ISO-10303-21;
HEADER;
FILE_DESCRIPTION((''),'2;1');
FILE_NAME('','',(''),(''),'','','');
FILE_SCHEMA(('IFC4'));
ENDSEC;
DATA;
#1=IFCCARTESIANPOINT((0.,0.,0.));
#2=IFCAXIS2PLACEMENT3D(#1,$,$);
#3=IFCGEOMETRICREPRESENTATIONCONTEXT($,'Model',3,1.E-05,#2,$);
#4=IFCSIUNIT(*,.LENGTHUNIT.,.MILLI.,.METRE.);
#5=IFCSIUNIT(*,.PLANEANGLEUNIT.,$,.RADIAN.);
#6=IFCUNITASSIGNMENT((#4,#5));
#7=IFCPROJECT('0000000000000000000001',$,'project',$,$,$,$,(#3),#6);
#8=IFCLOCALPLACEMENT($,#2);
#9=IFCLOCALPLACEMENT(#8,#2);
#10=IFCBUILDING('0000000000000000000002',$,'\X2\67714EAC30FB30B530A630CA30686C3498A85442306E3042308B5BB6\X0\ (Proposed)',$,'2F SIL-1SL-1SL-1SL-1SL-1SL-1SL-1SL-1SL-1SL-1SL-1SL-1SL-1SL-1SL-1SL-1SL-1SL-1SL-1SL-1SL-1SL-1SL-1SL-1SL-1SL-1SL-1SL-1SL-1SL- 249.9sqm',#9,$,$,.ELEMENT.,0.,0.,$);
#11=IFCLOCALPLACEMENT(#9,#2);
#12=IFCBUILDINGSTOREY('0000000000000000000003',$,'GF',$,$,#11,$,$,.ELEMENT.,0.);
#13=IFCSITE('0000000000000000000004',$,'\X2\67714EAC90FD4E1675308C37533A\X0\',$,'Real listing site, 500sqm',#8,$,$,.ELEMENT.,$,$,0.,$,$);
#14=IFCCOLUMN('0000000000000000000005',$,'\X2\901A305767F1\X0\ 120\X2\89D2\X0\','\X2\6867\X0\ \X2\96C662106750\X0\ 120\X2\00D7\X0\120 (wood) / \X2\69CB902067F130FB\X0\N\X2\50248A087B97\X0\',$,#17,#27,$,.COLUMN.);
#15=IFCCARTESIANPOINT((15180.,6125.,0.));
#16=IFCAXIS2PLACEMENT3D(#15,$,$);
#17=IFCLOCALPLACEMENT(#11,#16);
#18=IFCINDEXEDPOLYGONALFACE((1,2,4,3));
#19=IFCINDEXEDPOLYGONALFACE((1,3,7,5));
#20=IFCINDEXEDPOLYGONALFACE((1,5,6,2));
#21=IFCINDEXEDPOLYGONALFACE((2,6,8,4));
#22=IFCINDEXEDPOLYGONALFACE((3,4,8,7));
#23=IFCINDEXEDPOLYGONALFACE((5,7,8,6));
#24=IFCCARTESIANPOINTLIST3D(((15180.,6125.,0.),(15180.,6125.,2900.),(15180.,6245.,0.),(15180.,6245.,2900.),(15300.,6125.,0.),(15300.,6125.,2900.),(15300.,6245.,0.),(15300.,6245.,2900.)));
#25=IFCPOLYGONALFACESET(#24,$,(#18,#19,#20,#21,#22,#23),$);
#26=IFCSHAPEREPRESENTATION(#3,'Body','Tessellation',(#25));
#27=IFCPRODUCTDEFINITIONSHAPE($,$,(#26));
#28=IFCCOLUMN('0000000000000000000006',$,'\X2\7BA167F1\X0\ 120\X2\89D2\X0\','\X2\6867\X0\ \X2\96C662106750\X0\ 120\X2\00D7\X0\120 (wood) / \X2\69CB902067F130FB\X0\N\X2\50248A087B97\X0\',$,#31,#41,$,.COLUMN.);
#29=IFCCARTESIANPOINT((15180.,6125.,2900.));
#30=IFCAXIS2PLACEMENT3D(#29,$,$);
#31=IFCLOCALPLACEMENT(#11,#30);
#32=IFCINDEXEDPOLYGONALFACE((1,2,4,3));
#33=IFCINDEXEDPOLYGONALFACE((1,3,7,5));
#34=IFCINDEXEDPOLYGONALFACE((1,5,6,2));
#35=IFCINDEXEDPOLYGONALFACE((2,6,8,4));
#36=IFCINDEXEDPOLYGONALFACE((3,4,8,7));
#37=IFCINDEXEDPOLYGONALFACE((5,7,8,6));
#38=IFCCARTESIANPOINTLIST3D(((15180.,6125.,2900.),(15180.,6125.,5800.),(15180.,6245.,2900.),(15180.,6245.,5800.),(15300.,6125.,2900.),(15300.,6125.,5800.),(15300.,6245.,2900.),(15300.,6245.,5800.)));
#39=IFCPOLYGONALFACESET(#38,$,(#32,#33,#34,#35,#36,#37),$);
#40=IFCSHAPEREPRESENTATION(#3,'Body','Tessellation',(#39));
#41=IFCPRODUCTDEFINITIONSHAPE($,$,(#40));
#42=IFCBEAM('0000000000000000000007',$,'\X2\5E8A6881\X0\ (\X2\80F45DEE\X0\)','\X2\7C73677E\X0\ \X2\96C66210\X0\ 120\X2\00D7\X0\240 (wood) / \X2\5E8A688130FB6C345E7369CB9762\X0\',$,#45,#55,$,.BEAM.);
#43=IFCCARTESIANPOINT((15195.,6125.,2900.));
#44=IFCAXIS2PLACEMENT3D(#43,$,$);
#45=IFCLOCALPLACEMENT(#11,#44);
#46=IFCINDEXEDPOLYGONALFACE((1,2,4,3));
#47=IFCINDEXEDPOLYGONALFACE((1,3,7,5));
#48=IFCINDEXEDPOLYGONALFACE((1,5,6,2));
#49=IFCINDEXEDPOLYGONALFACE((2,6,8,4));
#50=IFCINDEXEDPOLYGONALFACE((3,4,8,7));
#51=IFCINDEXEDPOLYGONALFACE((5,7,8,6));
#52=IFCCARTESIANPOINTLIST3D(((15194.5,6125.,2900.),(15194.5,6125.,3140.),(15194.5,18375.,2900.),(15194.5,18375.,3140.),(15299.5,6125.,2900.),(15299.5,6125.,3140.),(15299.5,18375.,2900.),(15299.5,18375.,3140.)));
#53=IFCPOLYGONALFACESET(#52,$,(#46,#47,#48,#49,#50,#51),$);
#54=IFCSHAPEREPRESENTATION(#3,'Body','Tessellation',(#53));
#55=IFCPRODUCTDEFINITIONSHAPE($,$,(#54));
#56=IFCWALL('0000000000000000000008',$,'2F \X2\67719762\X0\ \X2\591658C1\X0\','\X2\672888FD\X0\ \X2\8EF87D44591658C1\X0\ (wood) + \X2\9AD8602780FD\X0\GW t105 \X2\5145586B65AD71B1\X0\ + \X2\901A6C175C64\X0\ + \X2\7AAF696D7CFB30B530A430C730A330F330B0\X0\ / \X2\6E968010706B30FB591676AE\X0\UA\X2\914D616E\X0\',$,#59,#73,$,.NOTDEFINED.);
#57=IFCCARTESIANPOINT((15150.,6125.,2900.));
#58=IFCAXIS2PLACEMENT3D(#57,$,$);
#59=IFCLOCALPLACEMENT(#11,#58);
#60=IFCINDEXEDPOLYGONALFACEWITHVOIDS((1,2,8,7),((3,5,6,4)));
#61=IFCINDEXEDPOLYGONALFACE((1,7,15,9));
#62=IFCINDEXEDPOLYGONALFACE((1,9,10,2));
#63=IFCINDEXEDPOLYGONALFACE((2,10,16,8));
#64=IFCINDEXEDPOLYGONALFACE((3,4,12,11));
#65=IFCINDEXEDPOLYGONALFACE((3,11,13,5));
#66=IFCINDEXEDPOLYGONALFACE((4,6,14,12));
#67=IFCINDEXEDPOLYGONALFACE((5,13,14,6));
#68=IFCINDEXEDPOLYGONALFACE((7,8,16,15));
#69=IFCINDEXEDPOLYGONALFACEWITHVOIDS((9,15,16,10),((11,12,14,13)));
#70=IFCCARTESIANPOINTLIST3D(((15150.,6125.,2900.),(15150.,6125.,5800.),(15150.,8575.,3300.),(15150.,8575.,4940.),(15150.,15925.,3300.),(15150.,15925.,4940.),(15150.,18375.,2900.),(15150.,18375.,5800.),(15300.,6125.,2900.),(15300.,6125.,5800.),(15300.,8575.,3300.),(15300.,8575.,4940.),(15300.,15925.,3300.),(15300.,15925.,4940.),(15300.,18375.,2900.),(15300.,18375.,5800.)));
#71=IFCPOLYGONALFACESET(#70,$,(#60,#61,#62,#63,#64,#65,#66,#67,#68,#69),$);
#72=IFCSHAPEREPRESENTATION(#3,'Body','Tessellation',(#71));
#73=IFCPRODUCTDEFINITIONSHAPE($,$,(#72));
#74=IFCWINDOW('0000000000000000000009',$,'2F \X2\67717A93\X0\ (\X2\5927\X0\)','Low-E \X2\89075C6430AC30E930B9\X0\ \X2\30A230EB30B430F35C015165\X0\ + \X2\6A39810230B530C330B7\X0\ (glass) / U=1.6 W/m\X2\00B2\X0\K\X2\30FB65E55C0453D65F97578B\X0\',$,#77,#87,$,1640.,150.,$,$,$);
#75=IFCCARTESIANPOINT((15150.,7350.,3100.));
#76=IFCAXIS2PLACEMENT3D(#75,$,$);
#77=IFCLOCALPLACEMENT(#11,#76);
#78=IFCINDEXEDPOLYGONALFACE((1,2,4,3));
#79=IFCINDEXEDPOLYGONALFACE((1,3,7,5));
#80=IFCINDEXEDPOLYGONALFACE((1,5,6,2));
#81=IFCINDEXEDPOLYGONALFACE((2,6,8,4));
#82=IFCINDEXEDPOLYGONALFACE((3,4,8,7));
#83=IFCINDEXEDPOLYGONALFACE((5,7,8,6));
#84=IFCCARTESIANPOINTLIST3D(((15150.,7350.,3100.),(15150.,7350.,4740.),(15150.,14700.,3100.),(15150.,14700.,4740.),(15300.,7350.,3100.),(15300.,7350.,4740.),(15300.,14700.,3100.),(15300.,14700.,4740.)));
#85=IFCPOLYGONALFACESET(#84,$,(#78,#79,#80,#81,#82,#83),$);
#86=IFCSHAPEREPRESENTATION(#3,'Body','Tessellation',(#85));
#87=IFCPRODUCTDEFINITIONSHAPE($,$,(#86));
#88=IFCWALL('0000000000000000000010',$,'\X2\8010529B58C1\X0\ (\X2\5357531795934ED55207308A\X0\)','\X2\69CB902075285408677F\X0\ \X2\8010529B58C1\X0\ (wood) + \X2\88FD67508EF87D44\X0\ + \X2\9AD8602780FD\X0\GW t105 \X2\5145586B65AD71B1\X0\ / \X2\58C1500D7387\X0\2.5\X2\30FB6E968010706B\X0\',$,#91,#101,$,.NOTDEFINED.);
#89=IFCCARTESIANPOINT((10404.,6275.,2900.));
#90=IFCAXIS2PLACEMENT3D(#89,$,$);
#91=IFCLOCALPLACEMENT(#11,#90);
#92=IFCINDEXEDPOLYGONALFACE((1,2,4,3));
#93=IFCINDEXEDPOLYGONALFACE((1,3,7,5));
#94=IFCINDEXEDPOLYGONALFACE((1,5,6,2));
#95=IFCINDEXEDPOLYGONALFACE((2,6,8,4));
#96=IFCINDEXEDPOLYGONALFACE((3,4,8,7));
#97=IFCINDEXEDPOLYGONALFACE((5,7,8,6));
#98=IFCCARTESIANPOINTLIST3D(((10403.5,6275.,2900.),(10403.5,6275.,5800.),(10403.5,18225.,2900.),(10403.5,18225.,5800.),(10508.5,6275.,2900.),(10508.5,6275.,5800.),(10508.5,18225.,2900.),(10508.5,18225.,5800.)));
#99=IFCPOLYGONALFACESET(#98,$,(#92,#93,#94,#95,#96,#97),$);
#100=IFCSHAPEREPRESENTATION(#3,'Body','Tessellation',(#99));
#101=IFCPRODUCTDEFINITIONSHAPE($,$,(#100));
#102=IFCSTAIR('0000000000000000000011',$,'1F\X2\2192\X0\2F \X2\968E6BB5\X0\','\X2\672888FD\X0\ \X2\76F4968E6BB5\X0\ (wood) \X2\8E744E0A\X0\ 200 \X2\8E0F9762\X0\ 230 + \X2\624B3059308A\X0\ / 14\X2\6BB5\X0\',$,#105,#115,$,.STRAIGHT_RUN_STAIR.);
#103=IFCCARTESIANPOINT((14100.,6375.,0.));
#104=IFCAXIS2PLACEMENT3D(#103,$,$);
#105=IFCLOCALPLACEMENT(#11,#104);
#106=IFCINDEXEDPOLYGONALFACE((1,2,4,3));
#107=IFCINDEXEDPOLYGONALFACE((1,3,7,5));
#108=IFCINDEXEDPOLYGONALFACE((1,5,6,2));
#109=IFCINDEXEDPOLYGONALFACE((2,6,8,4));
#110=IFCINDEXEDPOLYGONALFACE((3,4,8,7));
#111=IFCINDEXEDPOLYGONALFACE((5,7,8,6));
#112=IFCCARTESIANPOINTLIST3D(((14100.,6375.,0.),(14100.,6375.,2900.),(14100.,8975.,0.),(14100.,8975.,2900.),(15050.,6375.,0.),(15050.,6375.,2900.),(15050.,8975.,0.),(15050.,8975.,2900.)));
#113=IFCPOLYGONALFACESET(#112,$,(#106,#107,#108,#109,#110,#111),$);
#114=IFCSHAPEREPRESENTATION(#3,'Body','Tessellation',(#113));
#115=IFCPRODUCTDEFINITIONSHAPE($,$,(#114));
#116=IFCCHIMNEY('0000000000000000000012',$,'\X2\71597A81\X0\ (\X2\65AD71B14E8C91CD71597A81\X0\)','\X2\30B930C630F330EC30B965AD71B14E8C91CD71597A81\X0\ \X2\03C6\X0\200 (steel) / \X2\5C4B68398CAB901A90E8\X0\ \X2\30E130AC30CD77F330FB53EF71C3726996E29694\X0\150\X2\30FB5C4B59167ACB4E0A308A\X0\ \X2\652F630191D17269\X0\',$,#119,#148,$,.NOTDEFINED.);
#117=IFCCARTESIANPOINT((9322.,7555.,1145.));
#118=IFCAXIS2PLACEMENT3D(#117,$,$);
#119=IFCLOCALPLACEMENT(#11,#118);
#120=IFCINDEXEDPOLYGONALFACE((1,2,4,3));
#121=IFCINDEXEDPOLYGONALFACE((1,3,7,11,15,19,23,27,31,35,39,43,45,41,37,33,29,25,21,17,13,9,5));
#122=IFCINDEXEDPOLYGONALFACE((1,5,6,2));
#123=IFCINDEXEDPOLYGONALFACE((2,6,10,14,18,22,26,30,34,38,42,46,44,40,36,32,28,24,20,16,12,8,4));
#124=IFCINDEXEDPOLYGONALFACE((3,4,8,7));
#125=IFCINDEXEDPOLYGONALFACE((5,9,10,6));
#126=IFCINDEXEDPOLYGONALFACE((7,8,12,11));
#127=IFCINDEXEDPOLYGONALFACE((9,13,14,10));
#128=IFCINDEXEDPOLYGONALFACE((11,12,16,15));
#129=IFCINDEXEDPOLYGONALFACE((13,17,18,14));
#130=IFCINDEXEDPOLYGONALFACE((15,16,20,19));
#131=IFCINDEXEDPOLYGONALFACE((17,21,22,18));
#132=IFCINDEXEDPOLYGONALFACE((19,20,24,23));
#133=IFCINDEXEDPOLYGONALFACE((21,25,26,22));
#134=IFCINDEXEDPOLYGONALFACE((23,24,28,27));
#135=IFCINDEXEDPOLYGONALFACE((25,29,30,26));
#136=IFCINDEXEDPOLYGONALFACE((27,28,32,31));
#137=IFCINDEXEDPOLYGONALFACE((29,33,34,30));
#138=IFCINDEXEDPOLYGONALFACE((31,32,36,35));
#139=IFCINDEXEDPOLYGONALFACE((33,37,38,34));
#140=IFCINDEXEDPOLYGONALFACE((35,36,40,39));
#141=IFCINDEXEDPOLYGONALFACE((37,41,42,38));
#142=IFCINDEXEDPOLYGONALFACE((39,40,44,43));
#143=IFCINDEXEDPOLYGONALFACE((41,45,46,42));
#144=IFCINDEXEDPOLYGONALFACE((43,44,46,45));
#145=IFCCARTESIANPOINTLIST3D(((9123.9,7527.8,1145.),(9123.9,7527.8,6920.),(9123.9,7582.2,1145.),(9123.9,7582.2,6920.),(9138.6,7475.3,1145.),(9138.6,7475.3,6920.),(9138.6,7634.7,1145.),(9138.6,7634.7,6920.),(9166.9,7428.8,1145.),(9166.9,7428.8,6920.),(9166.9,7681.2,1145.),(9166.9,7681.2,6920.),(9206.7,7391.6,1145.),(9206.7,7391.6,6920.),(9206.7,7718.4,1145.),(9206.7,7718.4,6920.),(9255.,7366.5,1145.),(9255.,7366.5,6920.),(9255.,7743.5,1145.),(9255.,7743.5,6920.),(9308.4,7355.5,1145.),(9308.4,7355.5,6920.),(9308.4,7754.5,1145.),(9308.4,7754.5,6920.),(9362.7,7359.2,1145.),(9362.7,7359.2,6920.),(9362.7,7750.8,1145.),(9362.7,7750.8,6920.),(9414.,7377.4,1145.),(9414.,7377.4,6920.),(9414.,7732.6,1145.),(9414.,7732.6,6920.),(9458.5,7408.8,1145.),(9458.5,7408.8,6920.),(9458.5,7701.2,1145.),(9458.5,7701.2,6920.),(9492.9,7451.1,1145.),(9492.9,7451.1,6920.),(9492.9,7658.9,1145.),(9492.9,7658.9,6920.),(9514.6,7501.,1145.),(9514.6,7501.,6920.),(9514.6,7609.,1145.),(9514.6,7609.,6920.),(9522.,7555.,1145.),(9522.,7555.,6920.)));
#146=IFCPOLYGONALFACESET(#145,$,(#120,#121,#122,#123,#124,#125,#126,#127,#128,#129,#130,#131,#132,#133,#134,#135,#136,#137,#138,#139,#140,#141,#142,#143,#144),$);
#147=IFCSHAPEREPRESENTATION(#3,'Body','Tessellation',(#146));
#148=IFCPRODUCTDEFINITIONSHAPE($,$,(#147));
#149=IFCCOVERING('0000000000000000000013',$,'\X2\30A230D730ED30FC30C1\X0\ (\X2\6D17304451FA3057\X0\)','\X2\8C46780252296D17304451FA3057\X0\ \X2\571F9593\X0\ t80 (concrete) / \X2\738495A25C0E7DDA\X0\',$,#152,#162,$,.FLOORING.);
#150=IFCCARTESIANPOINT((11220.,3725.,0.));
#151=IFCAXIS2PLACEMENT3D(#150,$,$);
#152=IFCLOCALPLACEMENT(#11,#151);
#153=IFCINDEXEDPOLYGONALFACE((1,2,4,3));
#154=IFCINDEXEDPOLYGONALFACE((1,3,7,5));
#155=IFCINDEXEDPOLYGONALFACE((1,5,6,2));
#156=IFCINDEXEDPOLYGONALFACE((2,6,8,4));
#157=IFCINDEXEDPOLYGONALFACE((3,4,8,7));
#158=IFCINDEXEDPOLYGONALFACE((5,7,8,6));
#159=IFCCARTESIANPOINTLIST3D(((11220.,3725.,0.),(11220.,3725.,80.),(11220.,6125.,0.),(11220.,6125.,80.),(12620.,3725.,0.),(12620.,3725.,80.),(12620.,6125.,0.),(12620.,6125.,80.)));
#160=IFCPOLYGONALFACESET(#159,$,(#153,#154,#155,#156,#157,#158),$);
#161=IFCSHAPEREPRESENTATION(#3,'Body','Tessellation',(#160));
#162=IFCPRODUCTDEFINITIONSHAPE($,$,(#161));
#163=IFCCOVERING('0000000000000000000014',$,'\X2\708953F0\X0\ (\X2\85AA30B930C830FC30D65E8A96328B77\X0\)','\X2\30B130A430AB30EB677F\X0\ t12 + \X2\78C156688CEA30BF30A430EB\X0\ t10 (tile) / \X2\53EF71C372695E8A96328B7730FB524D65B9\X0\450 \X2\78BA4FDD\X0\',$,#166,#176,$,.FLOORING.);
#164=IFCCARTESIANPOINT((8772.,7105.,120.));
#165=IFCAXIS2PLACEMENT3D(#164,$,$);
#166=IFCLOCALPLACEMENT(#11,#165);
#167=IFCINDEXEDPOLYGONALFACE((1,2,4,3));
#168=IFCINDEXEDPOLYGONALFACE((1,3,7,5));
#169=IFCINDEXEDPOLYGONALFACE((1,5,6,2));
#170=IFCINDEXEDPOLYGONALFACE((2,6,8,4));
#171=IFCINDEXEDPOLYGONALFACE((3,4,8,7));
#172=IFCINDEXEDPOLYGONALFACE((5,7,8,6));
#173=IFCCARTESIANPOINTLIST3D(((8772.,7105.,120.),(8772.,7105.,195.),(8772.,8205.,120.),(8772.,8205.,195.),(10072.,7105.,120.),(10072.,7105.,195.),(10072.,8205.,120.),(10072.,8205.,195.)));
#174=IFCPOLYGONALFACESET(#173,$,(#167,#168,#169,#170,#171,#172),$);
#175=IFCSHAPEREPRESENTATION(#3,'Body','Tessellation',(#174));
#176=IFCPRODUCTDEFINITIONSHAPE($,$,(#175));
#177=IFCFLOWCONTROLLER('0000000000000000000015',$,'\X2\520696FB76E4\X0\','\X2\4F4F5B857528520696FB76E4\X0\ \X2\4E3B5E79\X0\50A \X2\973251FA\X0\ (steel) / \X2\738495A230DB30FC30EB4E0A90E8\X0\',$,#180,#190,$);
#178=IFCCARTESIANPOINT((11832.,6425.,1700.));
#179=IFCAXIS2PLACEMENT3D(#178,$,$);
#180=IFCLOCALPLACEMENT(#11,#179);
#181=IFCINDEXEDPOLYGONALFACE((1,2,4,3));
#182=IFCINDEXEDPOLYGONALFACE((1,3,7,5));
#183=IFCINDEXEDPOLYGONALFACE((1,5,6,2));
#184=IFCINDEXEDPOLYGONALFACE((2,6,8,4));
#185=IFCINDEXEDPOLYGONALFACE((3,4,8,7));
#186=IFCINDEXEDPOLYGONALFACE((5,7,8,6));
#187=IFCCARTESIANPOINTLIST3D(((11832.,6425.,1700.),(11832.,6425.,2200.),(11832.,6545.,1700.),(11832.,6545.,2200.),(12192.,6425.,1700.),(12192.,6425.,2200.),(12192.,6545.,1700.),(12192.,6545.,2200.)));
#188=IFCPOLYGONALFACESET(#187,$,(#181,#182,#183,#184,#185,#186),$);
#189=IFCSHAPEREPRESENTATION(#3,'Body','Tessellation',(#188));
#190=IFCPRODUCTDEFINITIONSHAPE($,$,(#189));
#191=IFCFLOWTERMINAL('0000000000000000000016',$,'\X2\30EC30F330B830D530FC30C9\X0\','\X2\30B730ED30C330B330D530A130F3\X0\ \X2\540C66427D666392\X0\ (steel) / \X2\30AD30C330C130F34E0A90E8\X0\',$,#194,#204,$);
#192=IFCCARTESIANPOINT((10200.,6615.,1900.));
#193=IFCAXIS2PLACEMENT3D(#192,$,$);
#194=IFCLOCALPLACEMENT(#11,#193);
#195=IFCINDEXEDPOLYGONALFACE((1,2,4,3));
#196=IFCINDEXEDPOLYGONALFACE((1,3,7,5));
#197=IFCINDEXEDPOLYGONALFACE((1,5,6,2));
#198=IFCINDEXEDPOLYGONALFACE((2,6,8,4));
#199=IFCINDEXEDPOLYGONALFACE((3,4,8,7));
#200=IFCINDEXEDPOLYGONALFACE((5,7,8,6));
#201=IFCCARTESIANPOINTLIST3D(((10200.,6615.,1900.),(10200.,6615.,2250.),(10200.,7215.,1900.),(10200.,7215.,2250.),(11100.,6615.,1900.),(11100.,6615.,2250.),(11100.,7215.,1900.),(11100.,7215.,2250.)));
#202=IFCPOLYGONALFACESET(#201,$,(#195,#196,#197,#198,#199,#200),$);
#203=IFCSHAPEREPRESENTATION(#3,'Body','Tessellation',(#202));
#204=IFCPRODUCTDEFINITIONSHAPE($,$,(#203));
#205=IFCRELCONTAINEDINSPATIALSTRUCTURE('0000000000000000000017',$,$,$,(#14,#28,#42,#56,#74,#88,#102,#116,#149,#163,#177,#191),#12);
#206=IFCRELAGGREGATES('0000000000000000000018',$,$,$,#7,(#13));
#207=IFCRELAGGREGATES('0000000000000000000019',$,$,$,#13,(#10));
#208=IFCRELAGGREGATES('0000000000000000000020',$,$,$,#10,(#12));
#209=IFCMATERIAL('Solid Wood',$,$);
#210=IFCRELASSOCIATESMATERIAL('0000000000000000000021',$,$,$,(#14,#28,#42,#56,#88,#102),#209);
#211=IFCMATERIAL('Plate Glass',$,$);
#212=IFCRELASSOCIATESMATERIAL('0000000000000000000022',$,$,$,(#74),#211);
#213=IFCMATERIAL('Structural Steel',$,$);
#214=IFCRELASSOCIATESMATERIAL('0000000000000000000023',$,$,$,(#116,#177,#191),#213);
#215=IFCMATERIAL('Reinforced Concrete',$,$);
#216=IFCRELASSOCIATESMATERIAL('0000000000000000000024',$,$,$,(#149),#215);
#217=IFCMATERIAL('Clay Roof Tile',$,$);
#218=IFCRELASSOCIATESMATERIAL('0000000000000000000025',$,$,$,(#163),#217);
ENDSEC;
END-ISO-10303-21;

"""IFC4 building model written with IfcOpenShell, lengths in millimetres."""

from ifc_helpers import new_model, si_unit, frame, frame_2d, origin, origin_2d, place, context, project, spatial, rectangle, circle, extrude, material, element, fill, save


model = new_model("IFC4")

# Units and contexts
model_context = context("Model", 3, precision=1e-05, world=origin())
ifc_project = project(units=[si_unit("LENGTHUNIT", "METRE", prefix="MILLI"), si_unit("PLANEANGLEUNIT", "RADIAN")], contexts=[model_context])

# Site, building, storey
site_placement = place(None, origin())
site = spatial("IfcSite", under=ifc_project, at=site_placement, Name="東京都世田谷区", ObjectType="Real listing site, 500sqm", CompositionType="ELEMENT", RefElevation=0.0)
building_placement = place(site_placement, origin())
building = spatial("IfcBuilding", under=site, at=building_placement, Name="東京・サウナと水風呂のある家 (Proposed)", ObjectType="2F SIL-1SL-1SL-1SL-1SL-1SL-1SL-1SL-1SL-1SL-1SL-1SL-1SL-1SL-1SL-1SL-1SL-1SL-1SL-1SL-1SL-1SL-1SL-1SL-1SL-1SL-1SL-1SL-1SL-1SL- 249.9sqm", CompositionType="ELEMENT", ElevationOfRefHeight=0.0, ElevationOfTerrain=0.0)
storey_placement = place(building_placement, origin())
storey = spatial("IfcBuildingStorey", under=building, at=storey_placement, Name="GF", CompositionType="ELEMENT", Elevation=0.0)

# Columns
ifc_material_1 = material(Name="Solid Wood")
column_1_placement = place(storey_placement, frame((15180.0, 6125.0, 0.0)))
element("IfcColumn", 1, at=column_1_placement, inside=storey, material=ifc_material_1, Name="通し柱 120角", Description="桧 集成材 120×120 (wood) / 構造柱・N値計算", PredefinedType="COLUMN", context=model_context, shape_type="SweptSolid", body=[
    extrude(rectangle(XDim=120.0, YDim=120.0, at=frame_2d((60.0, 60.0))), frame((15180.0, 6125.0, 0.0)), (0.0, 0.0, 1.0), 2900.0),
])
column_2_placement = place(storey_placement, frame((15180.0, 6125.0, 2900.0)))
element("IfcColumn", 2, at=column_2_placement, inside=storey, material=ifc_material_1, Name="管柱 120角", Description="桧 集成材 120×120 (wood) / 構造柱・N値計算", PredefinedType="COLUMN", context=model_context, shape_type="SweptSolid", body=[
    extrude(rectangle(XDim=120.0, YDim=120.0, at=frame_2d((60.0, 60.0))), frame((15180.0, 6125.0, 2900.0)), (0.0, 0.0, 1.0), 2900.0),
])

# Beam
beam_1_placement = place(storey_placement, frame((15195.0, 6125.0, 2900.0)))
element("IfcBeam", 3, at=beam_1_placement, inside=storey, material=ifc_material_1, Name="床梁 (胴差)", Description="米松 集成 120×240 (wood) / 床梁・水平構面", PredefinedType="BEAM", context=model_context, shape_type="SweptSolid", body=[
    extrude(rectangle(XDim=105.0, YDim=12250.0, at=frame_2d((52.0, 6125.0))), frame((15195.0, 6125.0, 2900.0)), (0.0, 0.0, 1.0), 240.0),
])

# Shared definitions
ifc_material_2 = material(Name="Plate Glass")

# Wall, opening, window
wall_1_placement = place(storey_placement, frame((15150.0, 6125.0, 2900.0)))
wall_1 = element("IfcWall", 4, at=wall_1_placement, inside=storey, material=ifc_material_1, Name="2F 東面 外壁", Description="木製 軸組外壁 (wood) + 高性能GW t105 充填断熱 + 通気層 + 窯業系サイディング / 準耐火・外皮UA配慮", PredefinedType="NOTDEFINED", context=model_context, shape_type="SweptSolid", body=[
    extrude(rectangle(XDim=150.0, YDim=12250.0, at=frame_2d((75.0, 6125.0))), frame((15150.0, 6125.0, 2900.0)), (0.0, 0.0, 1.0), 2900.0),
])
opening_1_placement = place(storey_placement, frame((15150.0, 7350.0, 3100.0)))
opening_1 = element("IfcOpeningElement", 5, at=opening_1_placement, cuts=wall_1, PredefinedType="NOTDEFINED", context=model_context, shape_type="SweptSolid", body=[
    extrude(rectangle(XDim=150.0, YDim=7350.0, at=frame_2d((75.0, 3675.0))), frame((15150.0, 7350.0, 3100.0)), (0.0, 0.0, 1.0), 1640.0),
])
window_1_placement = place(storey_placement, frame((15150.0, 7350.0, 3100.0)))
window_1 = element("IfcWindow", 6, at=window_1_placement, inside=storey, material=ifc_material_2, Name="2F 東窓 (大)", Description="Low-E 複層ガラス アルゴン封入 + 樹脂サッシ (glass) / U=1.6 W/m²K・日射取得型", OverallHeight=1640.0, OverallWidth=150.0, context=model_context, shape_type="SweptSolid", body=[
    extrude(rectangle(XDim=150.0, YDim=7350.0, at=frame_2d((75.0, 3675.0))), frame((15150.0, 7350.0, 3100.0)), (0.0, 0.0, 1.0), 1640.0),
])
fill(opening_1, window_1)

# Wall
wall_2_placement = place(storey_placement, frame((10404.0, 6275.0, 2900.0)))
element("IfcWall", 7, at=wall_2_placement, inside=storey, material=ifc_material_1, Name="耐力壁 (南北間仕切り)", Description="構造用合板 耐力壁 (wood) + 製材軸組 + 高性能GW t105 充填断熱 / 壁倍率2.5・準耐火", PredefinedType="NOTDEFINED", context=model_context, shape_type="SweptSolid", body=[
    extrude(rectangle(XDim=105.0, YDim=11950.0, at=frame_2d((52.0, 5975.0))), frame((10404.0, 6275.0, 2900.0)), (0.0, 0.0, 1.0), 2900.0),
])

# Stair
stair_placement = place(storey_placement, frame((14100.0, 6375.0, 0.0)))
element("IfcStair", 8, at=stair_placement, inside=storey, material=ifc_material_1, Name="1F→2F 階段", Description="木製 直階段 (wood) 蹴上 200 踏面 230 + 手すり / 14段", PredefinedType="STRAIGHT_RUN_STAIR", context=model_context, shape_type="SweptSolid", body=[
    extrude(rectangle(XDim=950.0, YDim=2600.0, at=frame_2d((475.0, 1300.0))), frame((14100.0, 6375.0, 0.0)), (0.0, 0.0, 1.0), 2900.0),
])

# Chimney
ifc_material_3 = material(Name="Structural Steel")
chimney_placement = place(storey_placement, frame((9322.0, 7555.0, 1145.0)))
element("IfcChimney", 9, at=chimney_placement, inside=storey, material=ifc_material_3, Name="煙突 (断熱二重煙突)", Description="ステンレス断熱二重煙突 φ200 (steel) / 屋根貫通部 メガネ石・可燃物離隔150・屋外立上り 支持金物", PredefinedType="NOTDEFINED", context=model_context, shape_type="SweptSolid", body=[
    extrude(circle(Radius=200.0, at=origin_2d()), frame((9322.0, 7555.0, 1145.0)), (0.0, 0.0, 1.0), 5775.0),
])

# Coverings
ifc_material_4 = material(Name="Reinforced Concrete")
covering_1_placement = place(storey_placement, frame((11220.0, 3725.0, 0.0)))
element("IfcCovering", 10, at=covering_1_placement, inside=storey, material=ifc_material_4, Name="アプローチ (洗い出し)", Description="豆砂利洗い出し 土間 t80 (concrete) / 玄関導線", PredefinedType="FLOORING", context=model_context, shape_type="SweptSolid", body=[
    extrude(rectangle(XDim=1400.0, YDim=2400.0, at=frame_2d((700.0, 1200.0))), frame((11220.0, 3725.0, 0.0)), (0.0, 0.0, 1.0), 80.0),
])
ifc_material_5 = material(Name="Clay Roof Tile")
covering_2_placement = place(storey_placement, frame((8772.0, 7105.0, 120.0)))
element("IfcCovering", 11, at=covering_2_placement, inside=storey, material=ifc_material_5, Name="炉台 (薪ストーブ床防護)", Description="ケイカル板 t12 + 磁器質タイル t10 (tile) / 可燃物床防護・前方450 確保", PredefinedType="FLOORING", context=model_context, shape_type="SweptSolid", body=[
    extrude(rectangle(XDim=1300.0, YDim=1100.0, at=frame_2d((650.0, 550.0))), frame((8772.0, 7105.0, 120.0)), (0.0, 0.0, 1.0), 75.0),
])

# Flow controller
flow_controller_placement = place(storey_placement, frame((11832.0, 6425.0, 1700.0)))
element("IfcFlowController", 12, at=flow_controller_placement, inside=storey, material=ifc_material_3, Name="分電盤", Description="住宅用分電盤 主幹50A 露出 (steel) / 玄関ホール上部", context=model_context, shape_type="SweptSolid", body=[
    extrude(rectangle(XDim=360.0, YDim=120.0, at=frame_2d((180.0, 60.0))), frame((11832.0, 6425.0, 1700.0)), (0.0, 0.0, 1.0), 500.0),
])

# Flow terminal
flow_terminal_1_placement = place(storey_placement, frame((10200.0, 6615.0, 1900.0)))
element("IfcFlowTerminal", 13, at=flow_terminal_1_placement, inside=storey, material=ifc_material_3, Name="レンジフード", Description="シロッコファン 同時給排 (steel) / キッチン上部", context=model_context, shape_type="SweptSolid", body=[
    extrude(rectangle(XDim=900.0, YDim=600.0, at=frame_2d((450.0, 300.0))), frame((10200.0, 6615.0, 1900.0)), (0.0, 0.0, 1.0), 350.0),
])

save(model, "model.ifc")
